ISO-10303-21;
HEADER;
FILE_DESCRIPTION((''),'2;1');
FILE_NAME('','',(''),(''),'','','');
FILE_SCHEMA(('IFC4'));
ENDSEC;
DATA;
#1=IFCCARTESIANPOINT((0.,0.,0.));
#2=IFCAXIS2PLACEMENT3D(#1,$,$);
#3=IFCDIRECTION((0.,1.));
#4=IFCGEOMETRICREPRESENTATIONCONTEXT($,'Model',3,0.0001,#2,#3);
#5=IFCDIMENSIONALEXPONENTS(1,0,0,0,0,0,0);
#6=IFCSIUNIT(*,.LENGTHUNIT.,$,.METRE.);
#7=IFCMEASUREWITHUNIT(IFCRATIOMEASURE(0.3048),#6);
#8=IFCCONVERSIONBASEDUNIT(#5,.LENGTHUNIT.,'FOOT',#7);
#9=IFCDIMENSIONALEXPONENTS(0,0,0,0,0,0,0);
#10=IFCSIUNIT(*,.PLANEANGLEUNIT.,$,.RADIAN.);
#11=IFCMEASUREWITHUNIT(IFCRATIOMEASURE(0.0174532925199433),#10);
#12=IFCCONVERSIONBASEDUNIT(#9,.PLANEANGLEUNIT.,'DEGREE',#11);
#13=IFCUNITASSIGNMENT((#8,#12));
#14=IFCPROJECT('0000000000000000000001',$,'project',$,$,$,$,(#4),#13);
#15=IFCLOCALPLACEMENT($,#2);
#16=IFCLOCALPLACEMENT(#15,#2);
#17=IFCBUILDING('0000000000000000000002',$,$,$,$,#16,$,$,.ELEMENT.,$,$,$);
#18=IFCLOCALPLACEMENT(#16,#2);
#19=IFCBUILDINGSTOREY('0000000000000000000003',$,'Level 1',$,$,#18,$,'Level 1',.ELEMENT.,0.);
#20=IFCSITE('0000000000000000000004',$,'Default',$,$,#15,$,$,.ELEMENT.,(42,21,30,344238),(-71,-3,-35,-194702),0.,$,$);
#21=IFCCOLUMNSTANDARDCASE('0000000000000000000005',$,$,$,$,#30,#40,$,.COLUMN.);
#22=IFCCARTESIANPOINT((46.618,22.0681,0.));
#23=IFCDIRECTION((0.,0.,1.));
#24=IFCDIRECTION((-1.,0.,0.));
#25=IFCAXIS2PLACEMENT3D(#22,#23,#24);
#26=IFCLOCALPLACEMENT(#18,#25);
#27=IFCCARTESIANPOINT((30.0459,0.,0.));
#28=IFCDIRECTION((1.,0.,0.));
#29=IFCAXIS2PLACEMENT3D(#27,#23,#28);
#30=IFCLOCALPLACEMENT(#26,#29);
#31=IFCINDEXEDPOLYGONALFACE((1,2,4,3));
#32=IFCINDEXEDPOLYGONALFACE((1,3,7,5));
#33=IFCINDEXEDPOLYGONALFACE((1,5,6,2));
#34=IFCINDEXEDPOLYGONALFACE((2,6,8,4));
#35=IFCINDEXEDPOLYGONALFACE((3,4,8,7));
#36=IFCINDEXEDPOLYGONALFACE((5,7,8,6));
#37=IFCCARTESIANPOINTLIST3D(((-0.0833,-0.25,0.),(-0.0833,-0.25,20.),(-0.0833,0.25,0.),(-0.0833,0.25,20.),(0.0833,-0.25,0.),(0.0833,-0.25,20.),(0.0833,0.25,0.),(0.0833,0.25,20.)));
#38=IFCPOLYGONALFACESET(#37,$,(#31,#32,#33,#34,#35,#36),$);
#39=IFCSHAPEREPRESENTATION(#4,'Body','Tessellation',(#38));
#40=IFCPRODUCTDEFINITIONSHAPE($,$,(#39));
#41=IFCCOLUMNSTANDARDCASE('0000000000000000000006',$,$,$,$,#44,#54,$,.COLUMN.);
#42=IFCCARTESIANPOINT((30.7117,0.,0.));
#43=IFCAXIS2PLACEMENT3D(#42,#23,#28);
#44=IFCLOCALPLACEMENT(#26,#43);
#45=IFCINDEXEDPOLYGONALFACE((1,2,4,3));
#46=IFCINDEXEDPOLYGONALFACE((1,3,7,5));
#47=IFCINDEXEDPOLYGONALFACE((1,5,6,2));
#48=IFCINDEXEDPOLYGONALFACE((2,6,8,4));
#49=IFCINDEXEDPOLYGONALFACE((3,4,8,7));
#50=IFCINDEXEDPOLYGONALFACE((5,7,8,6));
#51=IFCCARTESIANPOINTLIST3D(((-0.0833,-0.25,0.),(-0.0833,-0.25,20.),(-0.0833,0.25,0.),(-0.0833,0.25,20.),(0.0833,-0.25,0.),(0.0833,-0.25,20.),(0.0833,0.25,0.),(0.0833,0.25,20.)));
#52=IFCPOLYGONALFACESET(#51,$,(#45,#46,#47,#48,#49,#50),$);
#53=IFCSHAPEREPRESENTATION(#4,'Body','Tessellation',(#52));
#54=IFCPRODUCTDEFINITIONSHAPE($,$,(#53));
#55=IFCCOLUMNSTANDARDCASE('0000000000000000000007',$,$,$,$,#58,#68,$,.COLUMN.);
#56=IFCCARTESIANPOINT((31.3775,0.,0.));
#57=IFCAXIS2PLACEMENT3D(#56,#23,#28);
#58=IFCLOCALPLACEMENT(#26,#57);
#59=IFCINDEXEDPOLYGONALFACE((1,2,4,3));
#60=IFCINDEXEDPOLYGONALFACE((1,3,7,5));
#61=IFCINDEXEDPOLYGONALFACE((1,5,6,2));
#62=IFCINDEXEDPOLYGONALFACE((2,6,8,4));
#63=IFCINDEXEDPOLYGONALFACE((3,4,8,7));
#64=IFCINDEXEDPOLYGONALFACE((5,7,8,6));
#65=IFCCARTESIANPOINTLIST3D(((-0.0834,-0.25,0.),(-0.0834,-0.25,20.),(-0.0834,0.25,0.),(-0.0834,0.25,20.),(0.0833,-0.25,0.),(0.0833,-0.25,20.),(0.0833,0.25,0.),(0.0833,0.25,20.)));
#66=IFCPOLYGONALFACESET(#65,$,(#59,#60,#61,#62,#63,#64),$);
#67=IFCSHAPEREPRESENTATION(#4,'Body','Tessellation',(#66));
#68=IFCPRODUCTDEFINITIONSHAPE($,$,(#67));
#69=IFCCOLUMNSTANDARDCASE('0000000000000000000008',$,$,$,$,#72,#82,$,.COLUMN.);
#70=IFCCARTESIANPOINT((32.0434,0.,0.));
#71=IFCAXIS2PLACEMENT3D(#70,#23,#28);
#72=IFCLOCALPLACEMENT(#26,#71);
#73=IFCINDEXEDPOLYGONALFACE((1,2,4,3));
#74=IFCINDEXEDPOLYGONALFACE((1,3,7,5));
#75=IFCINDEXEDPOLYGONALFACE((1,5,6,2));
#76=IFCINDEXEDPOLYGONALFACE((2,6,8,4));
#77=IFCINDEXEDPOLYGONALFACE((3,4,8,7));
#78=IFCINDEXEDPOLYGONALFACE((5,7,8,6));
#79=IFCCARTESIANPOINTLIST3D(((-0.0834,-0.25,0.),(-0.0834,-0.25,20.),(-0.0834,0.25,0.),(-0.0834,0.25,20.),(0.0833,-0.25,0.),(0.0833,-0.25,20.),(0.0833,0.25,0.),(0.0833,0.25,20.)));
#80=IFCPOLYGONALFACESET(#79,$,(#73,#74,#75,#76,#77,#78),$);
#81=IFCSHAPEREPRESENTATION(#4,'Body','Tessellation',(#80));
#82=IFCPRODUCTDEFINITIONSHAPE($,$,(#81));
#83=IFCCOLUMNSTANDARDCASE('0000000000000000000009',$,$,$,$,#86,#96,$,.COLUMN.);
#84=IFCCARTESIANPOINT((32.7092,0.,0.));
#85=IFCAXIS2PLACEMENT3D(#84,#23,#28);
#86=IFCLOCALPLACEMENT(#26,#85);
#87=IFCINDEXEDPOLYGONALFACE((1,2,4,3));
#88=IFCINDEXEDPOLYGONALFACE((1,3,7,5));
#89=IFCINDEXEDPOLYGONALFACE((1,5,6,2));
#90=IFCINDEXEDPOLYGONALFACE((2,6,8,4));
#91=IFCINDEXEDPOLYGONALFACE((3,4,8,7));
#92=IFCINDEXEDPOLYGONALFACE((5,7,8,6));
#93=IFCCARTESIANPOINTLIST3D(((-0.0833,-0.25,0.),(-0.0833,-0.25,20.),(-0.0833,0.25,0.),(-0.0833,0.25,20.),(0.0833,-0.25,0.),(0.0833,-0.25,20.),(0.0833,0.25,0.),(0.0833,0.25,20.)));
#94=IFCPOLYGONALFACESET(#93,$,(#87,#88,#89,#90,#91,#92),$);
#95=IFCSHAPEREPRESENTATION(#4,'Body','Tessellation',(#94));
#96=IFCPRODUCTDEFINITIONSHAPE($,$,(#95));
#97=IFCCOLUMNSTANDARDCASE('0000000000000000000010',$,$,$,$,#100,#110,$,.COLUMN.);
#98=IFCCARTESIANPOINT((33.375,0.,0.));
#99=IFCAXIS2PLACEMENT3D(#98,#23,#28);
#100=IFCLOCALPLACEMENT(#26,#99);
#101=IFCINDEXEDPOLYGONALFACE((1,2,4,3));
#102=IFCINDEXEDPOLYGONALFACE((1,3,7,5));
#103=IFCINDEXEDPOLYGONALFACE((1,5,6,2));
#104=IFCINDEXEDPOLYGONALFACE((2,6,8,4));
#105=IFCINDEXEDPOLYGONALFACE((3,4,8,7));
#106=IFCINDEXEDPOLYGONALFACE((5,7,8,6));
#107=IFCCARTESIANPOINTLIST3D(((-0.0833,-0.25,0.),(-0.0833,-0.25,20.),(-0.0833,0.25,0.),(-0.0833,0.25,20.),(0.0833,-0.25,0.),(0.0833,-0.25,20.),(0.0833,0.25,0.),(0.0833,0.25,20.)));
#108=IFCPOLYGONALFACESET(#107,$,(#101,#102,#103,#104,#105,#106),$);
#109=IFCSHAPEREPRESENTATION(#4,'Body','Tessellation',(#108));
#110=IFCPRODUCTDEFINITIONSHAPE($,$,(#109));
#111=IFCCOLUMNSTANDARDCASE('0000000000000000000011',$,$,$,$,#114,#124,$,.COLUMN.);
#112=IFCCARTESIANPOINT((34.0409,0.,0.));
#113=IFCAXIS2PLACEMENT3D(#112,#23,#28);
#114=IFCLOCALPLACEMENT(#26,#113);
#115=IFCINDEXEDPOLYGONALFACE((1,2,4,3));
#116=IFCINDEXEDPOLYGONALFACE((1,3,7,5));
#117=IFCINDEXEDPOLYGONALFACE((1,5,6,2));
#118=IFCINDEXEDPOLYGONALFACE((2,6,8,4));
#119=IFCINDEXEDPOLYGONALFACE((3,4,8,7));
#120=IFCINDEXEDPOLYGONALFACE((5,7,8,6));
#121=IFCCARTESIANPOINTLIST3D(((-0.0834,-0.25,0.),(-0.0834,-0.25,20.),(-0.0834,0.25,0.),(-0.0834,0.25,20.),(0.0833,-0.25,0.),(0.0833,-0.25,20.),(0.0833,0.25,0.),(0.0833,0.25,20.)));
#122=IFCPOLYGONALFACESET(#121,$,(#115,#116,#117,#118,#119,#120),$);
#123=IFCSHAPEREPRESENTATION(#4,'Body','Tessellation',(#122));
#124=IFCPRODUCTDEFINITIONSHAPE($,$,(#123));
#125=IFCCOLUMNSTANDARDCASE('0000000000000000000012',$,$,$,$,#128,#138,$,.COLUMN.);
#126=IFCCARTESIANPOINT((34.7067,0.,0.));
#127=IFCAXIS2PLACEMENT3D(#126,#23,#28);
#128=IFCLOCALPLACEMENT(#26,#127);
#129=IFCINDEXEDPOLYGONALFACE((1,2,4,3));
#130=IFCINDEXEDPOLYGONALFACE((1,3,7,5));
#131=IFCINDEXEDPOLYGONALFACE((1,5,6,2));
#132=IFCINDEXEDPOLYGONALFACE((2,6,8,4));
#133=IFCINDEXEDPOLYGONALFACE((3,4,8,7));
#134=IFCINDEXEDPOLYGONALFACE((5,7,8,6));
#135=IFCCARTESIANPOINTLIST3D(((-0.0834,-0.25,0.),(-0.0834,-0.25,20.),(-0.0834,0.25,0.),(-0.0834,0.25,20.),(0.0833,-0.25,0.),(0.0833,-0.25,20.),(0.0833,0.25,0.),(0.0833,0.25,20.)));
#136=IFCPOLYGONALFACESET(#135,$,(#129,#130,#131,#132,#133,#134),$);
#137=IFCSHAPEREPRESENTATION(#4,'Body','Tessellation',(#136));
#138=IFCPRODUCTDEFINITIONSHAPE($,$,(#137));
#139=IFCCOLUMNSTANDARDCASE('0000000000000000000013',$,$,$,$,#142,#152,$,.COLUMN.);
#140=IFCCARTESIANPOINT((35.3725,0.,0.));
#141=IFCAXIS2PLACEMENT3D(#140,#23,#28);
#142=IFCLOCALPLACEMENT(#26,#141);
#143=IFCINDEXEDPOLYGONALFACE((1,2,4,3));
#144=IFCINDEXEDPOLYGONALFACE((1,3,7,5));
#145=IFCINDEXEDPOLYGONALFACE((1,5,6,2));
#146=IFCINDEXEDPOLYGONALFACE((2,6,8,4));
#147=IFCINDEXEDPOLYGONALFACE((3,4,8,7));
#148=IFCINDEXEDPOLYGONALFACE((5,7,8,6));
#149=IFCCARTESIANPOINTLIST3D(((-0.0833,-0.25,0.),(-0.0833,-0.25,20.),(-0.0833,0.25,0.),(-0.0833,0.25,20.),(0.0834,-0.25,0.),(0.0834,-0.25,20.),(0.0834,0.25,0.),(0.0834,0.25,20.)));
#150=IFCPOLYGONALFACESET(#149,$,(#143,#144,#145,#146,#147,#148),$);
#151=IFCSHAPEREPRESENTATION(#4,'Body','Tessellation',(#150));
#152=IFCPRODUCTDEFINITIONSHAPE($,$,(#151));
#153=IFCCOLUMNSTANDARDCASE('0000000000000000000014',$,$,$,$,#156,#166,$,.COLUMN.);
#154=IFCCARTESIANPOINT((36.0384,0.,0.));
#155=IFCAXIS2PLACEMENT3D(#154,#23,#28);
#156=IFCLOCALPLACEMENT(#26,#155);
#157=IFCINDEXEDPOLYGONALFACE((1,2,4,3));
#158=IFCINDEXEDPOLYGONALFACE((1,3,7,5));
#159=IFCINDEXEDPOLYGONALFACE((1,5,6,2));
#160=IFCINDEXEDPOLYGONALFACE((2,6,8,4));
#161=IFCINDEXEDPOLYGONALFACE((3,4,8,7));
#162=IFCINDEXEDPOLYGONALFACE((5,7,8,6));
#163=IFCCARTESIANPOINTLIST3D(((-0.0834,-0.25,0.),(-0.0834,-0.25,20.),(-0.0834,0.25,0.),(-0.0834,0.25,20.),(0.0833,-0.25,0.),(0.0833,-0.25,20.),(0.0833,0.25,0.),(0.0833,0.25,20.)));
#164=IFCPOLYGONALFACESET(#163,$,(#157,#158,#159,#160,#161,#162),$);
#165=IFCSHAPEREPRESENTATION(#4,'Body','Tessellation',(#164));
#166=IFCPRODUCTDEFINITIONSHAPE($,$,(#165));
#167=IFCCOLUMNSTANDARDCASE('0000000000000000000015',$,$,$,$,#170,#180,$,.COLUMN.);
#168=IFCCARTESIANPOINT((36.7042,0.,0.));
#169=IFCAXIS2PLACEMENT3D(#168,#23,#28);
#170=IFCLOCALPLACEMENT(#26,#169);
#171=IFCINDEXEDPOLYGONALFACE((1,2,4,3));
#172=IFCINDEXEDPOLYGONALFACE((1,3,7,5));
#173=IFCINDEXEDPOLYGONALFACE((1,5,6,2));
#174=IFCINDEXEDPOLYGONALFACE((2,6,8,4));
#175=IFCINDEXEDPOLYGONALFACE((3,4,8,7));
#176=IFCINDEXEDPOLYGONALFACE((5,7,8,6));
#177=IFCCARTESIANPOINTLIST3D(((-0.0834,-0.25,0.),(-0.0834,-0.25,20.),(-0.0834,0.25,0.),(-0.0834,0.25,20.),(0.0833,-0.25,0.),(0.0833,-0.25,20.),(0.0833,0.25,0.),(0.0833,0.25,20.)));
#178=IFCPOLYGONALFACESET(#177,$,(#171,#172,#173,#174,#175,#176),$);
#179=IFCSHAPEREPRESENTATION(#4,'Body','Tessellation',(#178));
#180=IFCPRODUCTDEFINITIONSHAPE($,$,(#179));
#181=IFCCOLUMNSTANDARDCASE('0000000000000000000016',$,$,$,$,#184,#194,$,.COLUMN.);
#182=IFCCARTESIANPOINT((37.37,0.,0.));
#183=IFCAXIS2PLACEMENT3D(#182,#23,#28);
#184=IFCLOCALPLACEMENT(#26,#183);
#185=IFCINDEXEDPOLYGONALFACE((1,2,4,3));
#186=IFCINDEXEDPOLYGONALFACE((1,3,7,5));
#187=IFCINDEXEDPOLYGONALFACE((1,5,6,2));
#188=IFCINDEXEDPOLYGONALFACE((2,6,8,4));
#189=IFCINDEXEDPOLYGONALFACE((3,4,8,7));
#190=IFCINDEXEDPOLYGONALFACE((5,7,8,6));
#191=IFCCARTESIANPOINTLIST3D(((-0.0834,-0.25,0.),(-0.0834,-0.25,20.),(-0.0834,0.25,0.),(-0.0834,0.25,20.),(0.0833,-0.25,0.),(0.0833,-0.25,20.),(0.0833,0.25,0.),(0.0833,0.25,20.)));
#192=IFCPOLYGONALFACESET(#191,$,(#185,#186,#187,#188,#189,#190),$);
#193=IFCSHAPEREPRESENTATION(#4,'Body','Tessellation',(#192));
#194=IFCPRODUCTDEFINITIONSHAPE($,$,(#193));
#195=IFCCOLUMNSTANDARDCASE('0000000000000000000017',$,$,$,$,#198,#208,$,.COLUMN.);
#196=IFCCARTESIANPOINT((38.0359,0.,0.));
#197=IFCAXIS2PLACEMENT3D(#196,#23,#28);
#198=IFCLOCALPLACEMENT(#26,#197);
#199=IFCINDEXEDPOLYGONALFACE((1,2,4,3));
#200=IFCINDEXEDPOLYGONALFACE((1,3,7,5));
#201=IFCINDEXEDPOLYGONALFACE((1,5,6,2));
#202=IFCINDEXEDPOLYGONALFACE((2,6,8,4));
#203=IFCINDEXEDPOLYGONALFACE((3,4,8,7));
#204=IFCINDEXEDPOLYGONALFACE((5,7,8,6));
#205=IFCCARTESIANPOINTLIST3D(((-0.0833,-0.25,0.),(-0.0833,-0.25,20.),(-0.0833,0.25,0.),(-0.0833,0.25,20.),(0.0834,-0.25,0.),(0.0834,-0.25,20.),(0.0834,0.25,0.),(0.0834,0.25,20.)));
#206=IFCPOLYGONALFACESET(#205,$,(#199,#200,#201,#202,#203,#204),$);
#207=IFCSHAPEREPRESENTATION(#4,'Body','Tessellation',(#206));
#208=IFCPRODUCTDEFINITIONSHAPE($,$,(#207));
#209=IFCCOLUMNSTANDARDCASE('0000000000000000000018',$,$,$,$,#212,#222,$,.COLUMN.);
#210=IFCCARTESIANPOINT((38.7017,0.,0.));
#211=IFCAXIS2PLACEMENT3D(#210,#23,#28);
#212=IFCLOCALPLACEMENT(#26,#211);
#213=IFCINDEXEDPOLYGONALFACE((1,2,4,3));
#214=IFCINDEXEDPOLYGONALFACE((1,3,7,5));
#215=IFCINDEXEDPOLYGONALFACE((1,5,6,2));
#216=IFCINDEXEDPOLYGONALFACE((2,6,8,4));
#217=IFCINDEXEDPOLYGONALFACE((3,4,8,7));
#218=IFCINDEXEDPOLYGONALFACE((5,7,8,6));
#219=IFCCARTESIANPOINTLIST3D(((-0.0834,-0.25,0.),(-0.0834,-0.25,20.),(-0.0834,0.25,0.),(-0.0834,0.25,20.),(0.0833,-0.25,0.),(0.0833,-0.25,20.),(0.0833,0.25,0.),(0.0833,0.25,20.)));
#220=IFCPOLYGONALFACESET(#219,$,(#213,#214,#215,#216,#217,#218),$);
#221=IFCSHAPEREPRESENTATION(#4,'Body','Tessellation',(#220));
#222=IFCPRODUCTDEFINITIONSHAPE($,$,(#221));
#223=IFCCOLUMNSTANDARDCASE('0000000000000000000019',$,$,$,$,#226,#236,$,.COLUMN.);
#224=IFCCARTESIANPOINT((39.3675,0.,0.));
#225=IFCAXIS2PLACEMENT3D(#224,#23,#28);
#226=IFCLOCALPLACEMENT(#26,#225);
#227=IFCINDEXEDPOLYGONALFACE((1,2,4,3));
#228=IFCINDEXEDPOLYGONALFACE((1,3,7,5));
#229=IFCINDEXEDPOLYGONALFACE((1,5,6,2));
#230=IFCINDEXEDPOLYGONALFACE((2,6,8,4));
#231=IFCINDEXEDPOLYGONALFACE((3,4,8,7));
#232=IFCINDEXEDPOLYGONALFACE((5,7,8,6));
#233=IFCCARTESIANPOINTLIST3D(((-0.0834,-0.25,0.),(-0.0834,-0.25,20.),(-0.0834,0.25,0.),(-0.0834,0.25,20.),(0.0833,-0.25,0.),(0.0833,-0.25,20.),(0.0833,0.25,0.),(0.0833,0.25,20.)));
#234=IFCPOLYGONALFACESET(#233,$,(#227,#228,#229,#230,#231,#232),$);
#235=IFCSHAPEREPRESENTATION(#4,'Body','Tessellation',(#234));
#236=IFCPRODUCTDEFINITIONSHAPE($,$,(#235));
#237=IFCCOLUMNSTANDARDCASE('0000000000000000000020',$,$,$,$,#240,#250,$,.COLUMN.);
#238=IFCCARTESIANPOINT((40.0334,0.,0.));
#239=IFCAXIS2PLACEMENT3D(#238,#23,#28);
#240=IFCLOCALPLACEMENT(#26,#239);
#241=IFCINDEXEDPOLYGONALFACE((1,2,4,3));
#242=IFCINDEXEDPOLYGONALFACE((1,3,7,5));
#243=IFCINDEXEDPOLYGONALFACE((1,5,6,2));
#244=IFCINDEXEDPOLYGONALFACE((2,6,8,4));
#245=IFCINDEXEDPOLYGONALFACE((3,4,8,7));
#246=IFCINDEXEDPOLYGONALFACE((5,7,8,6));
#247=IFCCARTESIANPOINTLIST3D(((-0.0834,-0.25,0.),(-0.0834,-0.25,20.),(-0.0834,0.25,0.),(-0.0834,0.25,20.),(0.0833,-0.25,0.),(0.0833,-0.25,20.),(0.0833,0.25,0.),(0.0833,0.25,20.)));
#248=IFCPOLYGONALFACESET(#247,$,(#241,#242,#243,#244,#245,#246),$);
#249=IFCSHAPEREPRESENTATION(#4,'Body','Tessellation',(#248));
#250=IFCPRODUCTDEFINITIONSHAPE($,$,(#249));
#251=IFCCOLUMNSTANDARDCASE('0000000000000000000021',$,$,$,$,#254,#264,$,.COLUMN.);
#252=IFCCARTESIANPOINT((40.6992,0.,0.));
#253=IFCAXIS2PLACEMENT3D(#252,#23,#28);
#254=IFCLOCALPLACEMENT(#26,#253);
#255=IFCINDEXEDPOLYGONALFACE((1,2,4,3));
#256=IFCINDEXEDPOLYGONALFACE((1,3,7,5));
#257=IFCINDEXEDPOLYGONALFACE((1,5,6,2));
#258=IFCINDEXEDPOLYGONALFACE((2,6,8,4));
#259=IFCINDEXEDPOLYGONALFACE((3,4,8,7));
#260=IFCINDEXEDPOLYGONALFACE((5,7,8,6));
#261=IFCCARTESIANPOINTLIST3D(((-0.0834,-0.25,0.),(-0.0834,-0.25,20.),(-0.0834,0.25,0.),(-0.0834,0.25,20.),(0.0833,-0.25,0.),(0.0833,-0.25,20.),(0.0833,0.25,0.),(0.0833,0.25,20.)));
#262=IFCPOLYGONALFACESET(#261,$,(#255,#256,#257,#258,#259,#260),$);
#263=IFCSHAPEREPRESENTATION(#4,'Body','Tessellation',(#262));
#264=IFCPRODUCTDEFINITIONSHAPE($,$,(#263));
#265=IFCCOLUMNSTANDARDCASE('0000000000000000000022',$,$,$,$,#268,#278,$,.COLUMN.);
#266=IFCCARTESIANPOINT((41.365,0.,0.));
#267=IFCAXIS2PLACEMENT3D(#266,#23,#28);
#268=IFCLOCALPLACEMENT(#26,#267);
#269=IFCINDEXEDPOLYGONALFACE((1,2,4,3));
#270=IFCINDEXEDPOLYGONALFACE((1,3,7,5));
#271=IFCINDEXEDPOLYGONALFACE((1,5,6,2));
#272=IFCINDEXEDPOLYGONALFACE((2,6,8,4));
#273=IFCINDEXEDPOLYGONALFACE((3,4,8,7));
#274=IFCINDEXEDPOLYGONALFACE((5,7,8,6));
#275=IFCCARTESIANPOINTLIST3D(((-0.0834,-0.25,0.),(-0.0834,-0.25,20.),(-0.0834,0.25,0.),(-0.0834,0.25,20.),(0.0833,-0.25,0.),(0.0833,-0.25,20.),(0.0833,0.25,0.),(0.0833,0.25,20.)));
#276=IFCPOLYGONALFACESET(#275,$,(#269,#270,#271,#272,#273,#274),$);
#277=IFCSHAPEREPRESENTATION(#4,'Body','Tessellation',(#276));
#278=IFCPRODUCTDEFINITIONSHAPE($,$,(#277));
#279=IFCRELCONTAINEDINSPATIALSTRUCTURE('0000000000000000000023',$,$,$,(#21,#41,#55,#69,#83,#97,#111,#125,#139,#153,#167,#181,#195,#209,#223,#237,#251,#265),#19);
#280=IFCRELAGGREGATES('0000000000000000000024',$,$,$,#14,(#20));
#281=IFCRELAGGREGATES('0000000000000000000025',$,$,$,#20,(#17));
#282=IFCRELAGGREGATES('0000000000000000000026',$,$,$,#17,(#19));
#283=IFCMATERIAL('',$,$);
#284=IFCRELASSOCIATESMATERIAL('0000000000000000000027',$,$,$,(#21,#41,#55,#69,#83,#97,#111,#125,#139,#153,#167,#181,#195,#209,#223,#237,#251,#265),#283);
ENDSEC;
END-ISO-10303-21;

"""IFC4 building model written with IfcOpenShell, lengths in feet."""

from ifc_helpers import new_model, entity, si_unit, converted_unit, direction, frame, origin, place, context, project, spatial, rectangle, extrude, material, element, save


model = new_model("IFC4")

# Units and contexts
model_context = context("Model", 3, precision=0.0001, world=origin(), true_north=direction((0.0, 1.0)))
ifc_project = project(units=[converted_unit("LENGTHUNIT", "FOOT", entity("IfcRatioMeasure", 0.3048), si_unit("LENGTHUNIT", "METRE"), dimensions=[1, 0, 0, 0, 0, 0, 0]), converted_unit("PLANEANGLEUNIT", "DEGREE", entity("IfcRatioMeasure", 0.0174532925199433), si_unit("PLANEANGLEUNIT", "RADIAN"), dimensions=[0, 0, 0, 0, 0, 0, 0])], contexts=[model_context])

# Site, building, storey
site_placement = place(None, origin())
site = spatial("IfcSite", under=ifc_project, at=site_placement, Name="Default", CompositionType="ELEMENT", RefLatitude=(42, 21, 30, 344238), RefLongitude=(-71, -3, -35, -194702), RefElevation=0.0)
building_placement = place(site_placement, origin())
building = spatial("IfcBuilding", under=site, at=building_placement, CompositionType="ELEMENT")
storey_placement = place(building_placement, origin())
storey = spatial("IfcBuildingStorey", under=building, at=storey_placement, Name="Level 1", LongName="Level 1", CompositionType="ELEMENT", Elevation=0.0)

# Columns
ifc_material = material(Name="")
placement = place(storey_placement, frame((46.618, 22.0681, 0.0), z_axis=(0.0, 0.0, 1.0), x_axis=(-1.0, 0.0, 0.0)))
for number, where, z_axis, x_axis in (
    (1, (30.0459, 0.0, 0.0), (0.0, 0.0, 1.0), (1.0, 0.0, 0.0)),
    (2, (30.7117, 0.0, 0.0), (0.0, 0.0, 1.0), (1.0, 0.0, 0.0)),
    (3, (31.3775, 0.0, 0.0), (0.0, 0.0, 1.0), (1.0, 0.0, 0.0)),
    (4, (32.0434, 0.0, 0.0), (0.0, 0.0, 1.0), (1.0, 0.0, 0.0)),
    (5, (32.7092, 0.0, 0.0), (0.0, 0.0, 1.0), (1.0, 0.0, 0.0)),
    (6, (33.375, 0.0, 0.0), (0.0, 0.0, 1.0), (1.0, 0.0, 0.0)),
    (7, (34.0409, 0.0, 0.0), (0.0, 0.0, 1.0), (1.0, 0.0, 0.0)),
    (8, (34.7067, 0.0, 0.0), (0.0, 0.0, 1.0), (1.0, 0.0, 0.0)),
    (9, (35.3725, 0.0, 0.0), (0.0, 0.0, 1.0), (1.0, 0.0, 0.0)),
    (10, (36.0384, 0.0, 0.0), (0.0, 0.0, 1.0), (1.0, 0.0, 0.0)),
    (11, (36.7042, 0.0, 0.0), (0.0, 0.0, 1.0), (1.0, 0.0, 0.0)),
    (12, (37.37, 0.0, 0.0), (0.0, 0.0, 1.0), (1.0, 0.0, 0.0)),
    (13, (38.0359, 0.0, 0.0), (0.0, 0.0, 1.0), (1.0, 0.0, 0.0)),
    (14, (38.7017, 0.0, 0.0), (0.0, 0.0, 1.0), (1.0, 0.0, 0.0)),
    (15, (39.3675, 0.0, 0.0), (0.0, 0.0, 1.0), (1.0, 0.0, 0.0)),
    (16, (40.0334, 0.0, 0.0), (0.0, 0.0, 1.0), (1.0, 0.0, 0.0)),
    (17, (40.6992, 0.0, 0.0), (0.0, 0.0, 1.0), (1.0, 0.0, 0.0)),
    (18, (41.365, 0.0, 0.0), (0.0, 0.0, 1.0), (1.0, 0.0, 0.0)),
):
    element("IfcColumnStandardCase", number, at=place(placement, frame(where, z_axis=z_axis, x_axis=x_axis)), inside=storey, material=ifc_material, PredefinedType="COLUMN", context=model_context, shape_type="SweptSolid", body=[
        extrude(rectangle(XDim=0.1667, YDim=0.5), origin(), (0.0, 0.0, 1.0), 20.0),
    ])

save(model, "model.ifc")
